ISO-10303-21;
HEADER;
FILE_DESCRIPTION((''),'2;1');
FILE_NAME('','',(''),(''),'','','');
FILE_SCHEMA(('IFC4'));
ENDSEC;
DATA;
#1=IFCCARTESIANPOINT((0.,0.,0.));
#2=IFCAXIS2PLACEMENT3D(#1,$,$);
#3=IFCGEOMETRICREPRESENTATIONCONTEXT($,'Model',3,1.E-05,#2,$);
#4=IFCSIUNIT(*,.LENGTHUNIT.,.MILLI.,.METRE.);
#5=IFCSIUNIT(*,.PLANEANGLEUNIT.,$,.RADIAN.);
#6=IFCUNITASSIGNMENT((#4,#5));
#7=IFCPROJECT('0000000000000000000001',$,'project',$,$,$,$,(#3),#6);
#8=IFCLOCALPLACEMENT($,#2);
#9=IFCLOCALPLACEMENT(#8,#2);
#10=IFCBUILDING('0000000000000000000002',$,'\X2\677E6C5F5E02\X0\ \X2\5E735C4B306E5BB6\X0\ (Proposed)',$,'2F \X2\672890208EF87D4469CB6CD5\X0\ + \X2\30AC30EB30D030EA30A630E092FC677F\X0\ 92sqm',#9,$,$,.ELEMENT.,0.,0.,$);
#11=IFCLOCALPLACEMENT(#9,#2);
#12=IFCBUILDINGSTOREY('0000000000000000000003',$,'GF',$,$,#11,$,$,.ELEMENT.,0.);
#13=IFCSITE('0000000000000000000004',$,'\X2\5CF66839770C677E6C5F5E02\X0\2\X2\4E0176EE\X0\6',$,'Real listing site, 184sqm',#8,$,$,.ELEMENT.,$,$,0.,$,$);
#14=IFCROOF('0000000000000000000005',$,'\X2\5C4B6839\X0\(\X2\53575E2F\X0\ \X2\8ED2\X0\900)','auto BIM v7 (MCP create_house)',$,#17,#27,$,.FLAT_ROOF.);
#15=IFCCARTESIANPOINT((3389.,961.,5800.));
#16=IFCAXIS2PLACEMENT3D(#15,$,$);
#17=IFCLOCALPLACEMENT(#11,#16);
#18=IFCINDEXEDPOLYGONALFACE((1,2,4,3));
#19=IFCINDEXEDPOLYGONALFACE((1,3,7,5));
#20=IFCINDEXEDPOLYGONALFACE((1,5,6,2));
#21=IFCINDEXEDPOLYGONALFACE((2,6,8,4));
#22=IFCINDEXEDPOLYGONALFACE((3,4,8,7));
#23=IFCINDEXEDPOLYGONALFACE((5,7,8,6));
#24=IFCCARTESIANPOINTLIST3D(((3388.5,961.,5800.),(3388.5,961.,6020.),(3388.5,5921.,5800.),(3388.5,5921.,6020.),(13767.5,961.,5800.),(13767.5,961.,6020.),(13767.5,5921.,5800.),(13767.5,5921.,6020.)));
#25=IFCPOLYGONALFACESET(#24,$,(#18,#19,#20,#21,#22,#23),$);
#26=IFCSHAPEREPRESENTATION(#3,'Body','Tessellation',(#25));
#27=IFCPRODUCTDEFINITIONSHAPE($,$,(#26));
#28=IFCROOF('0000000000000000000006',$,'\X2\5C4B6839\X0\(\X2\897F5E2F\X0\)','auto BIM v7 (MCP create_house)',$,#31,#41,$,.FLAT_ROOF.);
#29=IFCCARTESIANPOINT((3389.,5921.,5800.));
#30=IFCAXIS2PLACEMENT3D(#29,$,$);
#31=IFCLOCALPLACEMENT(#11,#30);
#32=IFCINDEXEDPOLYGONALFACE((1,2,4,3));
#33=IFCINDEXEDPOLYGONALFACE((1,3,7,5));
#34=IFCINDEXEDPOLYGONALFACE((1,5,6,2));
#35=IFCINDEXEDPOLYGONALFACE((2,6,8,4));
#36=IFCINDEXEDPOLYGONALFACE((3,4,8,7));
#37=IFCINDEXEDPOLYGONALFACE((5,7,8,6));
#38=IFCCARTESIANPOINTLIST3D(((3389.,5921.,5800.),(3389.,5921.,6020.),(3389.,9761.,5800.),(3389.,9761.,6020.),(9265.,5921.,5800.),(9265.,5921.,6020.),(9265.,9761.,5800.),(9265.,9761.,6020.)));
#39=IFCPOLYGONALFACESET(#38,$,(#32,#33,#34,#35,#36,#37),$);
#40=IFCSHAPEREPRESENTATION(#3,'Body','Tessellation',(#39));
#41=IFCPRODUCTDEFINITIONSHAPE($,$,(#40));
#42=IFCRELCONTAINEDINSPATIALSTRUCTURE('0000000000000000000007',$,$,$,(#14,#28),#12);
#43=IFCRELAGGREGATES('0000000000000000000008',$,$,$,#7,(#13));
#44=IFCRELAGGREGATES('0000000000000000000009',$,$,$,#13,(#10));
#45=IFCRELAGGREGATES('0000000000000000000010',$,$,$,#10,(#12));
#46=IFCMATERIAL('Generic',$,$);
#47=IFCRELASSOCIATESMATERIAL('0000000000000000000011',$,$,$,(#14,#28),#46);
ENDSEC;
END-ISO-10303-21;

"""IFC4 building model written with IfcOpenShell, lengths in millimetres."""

from ifc_helpers import new_model, si_unit, frame, frame_2d, origin, place, context, project, spatial, rectangle, extrude, material, element, save


model = new_model("IFC4")

# Units and contexts
model_context = context("Model", 3, precision=1e-05, world=origin())
ifc_project = project(units=[si_unit("LENGTHUNIT", "METRE", prefix="MILLI"), si_unit("PLANEANGLEUNIT", "RADIAN")], contexts=[model_context])

# Site, building, storey
site_placement = place(None, origin())
site = spatial("IfcSite", under=ifc_project, at=site_placement, Name="島根県松江市2丁目6", ObjectType="Real listing site, 184sqm", CompositionType="ELEMENT", RefElevation=0.0)
building_placement = place(site_placement, origin())
building = spatial("IfcBuilding", under=site, at=building_placement, Name="松江市 平屋の家 (Proposed)", ObjectType="2F 木造軸組構法 + ガルバリウム鋼板 92sqm", CompositionType="ELEMENT", ElevationOfRefHeight=0.0, ElevationOfTerrain=0.0)
storey_placement = place(building_placement, origin())
storey = spatial("IfcBuildingStorey", under=building, at=storey_placement, Name="GF", CompositionType="ELEMENT", Elevation=0.0)

# Shared definitions
ifc_material = material(Name="Generic")

# Roofs
roof_1_placement = place(storey_placement, frame((3389.0, 961.0, 5800.0)))
element("IfcRoof", 1, at=roof_1_placement, inside=storey, material=ifc_material, Name="屋根(南帯 軒900)", Description="auto BIM v7 (MCP create_house)", PredefinedType="FLAT_ROOF", context=model_context, shape_type="SweptSolid", body=[
    extrude(rectangle(XDim=10379.0, YDim=4960.0, at=frame_2d((5189.0, 2480.0))), frame((3389.0, 961.0, 5800.0)), (0.0, 0.0, 1.0), 220.0),
])
roof_2_placement = place(storey_placement, frame((3389.0, 5921.0, 5800.0)))
element("IfcRoof", 2, at=roof_2_placement, inside=storey, material=ifc_material, Name="屋根(西帯)", Description="auto BIM v7 (MCP create_house)", PredefinedType="FLAT_ROOF", context=model_context, shape_type="SweptSolid", body=[
    extrude(rectangle(XDim=5876.0, YDim=3840.0, at=frame_2d((2938.0, 1920.0))), frame((3389.0, 5921.0, 5800.0)), (0.0, 0.0, 1.0), 220.0),
])

save(model, "model.ifc")
